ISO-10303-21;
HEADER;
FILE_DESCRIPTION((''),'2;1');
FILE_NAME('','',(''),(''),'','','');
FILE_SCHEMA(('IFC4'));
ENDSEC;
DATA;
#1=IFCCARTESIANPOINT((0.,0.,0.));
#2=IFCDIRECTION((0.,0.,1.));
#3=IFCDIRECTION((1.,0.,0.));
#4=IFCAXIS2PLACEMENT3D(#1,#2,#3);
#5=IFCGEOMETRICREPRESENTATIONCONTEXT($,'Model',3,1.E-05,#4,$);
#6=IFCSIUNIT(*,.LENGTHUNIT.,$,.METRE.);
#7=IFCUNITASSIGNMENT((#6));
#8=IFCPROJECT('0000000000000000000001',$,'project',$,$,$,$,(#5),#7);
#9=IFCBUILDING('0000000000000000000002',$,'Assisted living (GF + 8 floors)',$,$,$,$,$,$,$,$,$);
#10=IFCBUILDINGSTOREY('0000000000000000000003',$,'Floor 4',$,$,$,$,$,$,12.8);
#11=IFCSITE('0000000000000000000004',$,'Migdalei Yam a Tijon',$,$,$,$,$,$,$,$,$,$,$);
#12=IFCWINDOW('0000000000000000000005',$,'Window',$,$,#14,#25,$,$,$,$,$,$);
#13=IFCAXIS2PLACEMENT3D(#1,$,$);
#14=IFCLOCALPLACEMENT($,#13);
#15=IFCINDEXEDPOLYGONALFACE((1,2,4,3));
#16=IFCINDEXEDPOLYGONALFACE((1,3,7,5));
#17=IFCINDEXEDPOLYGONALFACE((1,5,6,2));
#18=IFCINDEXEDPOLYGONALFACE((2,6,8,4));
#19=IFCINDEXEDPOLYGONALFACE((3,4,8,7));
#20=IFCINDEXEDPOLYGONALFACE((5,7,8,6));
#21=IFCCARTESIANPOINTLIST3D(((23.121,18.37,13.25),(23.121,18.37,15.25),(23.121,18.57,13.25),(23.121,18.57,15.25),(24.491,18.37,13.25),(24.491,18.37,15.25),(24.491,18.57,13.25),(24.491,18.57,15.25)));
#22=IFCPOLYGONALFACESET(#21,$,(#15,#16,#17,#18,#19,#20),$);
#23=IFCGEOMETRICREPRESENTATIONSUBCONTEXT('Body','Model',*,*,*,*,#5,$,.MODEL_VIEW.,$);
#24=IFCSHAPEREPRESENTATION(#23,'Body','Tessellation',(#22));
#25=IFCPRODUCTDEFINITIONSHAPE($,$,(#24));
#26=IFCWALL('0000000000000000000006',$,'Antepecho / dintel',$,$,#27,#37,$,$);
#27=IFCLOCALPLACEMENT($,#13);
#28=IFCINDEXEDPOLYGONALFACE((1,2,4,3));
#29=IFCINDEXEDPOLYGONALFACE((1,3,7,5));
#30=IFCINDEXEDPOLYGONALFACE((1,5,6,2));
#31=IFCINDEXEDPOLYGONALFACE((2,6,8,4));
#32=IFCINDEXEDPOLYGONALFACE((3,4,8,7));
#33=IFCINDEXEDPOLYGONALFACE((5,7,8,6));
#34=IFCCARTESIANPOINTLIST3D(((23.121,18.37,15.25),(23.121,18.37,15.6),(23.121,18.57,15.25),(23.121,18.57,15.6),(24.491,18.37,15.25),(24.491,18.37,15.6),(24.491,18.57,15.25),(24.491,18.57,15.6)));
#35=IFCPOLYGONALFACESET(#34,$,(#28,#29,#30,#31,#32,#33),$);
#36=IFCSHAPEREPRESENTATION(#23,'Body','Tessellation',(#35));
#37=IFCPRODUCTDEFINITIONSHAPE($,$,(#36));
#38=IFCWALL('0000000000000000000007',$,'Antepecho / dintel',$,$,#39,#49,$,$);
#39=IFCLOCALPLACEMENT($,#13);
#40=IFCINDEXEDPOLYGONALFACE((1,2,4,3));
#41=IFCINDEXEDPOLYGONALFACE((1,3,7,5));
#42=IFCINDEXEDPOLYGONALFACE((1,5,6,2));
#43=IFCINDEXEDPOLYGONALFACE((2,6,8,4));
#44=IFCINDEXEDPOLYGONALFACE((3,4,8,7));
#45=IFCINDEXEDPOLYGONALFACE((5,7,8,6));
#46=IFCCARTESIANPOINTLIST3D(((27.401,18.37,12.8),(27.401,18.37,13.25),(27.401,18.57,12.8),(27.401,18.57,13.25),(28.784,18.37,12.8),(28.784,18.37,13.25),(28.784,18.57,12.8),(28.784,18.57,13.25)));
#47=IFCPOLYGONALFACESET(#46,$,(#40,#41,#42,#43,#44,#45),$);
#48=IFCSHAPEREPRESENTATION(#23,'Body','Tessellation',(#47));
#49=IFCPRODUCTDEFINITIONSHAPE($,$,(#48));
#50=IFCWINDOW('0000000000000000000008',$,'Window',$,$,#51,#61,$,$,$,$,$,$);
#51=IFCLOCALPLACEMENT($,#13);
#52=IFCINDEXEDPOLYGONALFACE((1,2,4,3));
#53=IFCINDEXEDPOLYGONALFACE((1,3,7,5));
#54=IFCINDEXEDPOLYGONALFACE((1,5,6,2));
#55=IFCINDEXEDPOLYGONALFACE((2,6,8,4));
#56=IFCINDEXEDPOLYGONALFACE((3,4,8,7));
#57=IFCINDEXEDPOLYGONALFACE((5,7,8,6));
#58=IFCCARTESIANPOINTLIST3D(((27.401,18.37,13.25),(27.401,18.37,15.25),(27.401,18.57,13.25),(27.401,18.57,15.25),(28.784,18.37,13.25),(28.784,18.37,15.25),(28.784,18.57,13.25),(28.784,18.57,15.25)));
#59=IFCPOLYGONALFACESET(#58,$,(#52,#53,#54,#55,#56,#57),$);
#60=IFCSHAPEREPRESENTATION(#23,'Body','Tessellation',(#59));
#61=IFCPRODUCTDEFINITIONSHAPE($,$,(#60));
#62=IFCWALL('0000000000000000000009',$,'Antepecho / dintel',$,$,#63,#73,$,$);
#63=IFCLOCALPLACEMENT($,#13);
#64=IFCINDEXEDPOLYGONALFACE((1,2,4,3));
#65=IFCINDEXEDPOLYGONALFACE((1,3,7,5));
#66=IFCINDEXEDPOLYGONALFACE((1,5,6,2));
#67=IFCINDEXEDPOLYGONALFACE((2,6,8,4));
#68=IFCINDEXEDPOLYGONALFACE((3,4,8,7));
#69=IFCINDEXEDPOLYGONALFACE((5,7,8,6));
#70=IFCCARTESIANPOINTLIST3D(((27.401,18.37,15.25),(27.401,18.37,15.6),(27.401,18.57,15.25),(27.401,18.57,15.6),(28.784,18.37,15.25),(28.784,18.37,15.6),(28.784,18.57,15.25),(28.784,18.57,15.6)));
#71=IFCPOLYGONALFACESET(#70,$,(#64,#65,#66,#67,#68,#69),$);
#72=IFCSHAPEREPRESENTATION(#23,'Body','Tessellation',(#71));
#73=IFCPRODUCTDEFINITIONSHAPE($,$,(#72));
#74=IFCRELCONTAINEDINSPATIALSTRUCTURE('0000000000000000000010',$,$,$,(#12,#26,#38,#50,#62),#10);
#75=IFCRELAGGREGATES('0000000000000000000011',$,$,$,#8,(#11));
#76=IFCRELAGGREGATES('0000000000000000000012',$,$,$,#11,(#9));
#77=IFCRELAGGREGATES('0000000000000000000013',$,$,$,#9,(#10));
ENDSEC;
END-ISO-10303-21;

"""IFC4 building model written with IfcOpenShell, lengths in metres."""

from ifc_helpers import new_model, si_unit, frame, origin_with_axes, context, subcontext, project, spatial, line, indexed_curve, outline, extrude, element, save


model = new_model("IFC4")

# Units and contexts
model_context = context("Model", 3, precision=1e-05, world=origin_with_axes())
body_context = subcontext(model_context, "Body", "Model", "MODEL_VIEW")
ifc_project = project(units=[si_unit("LENGTHUNIT", "METRE")], contexts=[model_context])

# Site, building, storey
site = spatial("IfcSite", under=ifc_project, Name="Migdalei Yam a Tijon")
building = spatial("IfcBuilding", under=site, Name="Assisted living (GF + 8 floors)")
storey = spatial("IfcBuildingStorey", under=building, Name="Floor 4", Elevation=12.8)

# Window
element("IfcWindow", 1, inside=storey, Name="Window", context=body_context, shape_type="SweptSolid", body=[
    extrude(outline(indexed_curve([(0.0, 0.0), (1.37, 0.0), (1.37, 0.2), (0.0, 0.2)], segments=[line(1, 2, 3, 4, 1)])), frame((23.121, 18.37, 13.25), z_axis=(0.0, 0.0, 1.0), x_axis=(1.0, 0.0, 0.0)), (0.0, 0.0, 1.0), 2.0),
])

# Walls
element("IfcWall", 2, inside=storey, Name="Antepecho / dintel", context=body_context, shape_type="SweptSolid", body=[
    extrude(outline(indexed_curve([(0.0, 0.0), (1.37, 0.0), (1.37, 0.2), (0.0, 0.2)], segments=[line(1, 2, 3, 4, 1)])), frame((23.121, 18.37, 15.25), z_axis=(0.0, 0.0, 1.0), x_axis=(1.0, 0.0, 0.0)), (0.0, 0.0, 1.0), 0.35),
])
element("IfcWall", 3, inside=storey, Name="Antepecho / dintel", context=body_context, shape_type="SweptSolid", body=[
    extrude(outline(indexed_curve([(0.0, 0.0), (1.383, 0.0), (1.383, 0.2), (0.0, 0.2)], segments=[line(1, 2, 3, 4, 1)])), frame((27.401, 18.37, 12.8), z_axis=(0.0, 0.0, 1.0), x_axis=(1.0, 0.0, 0.0)), (0.0, 0.0, 1.0), 0.45),
])

# Window
element("IfcWindow", 4, inside=storey, Name="Window", context=body_context, shape_type="SweptSolid", body=[
    extrude(outline(indexed_curve([(0.0, 0.0), (1.383, 0.0), (1.383, 0.2), (0.0, 0.2)], segments=[line(1, 2, 3, 4, 1)])), frame((27.401, 18.37, 13.25), z_axis=(0.0, 0.0, 1.0), x_axis=(1.0, 0.0, 0.0)), (0.0, 0.0, 1.0), 2.0),
])

# Wall
element("IfcWall", 5, inside=storey, Name="Antepecho / dintel", context=body_context, shape_type="SweptSolid", body=[
    extrude(outline(indexed_curve([(0.0, 0.0), (1.383, 0.0), (1.383, 0.2), (0.0, 0.2)], segments=[line(1, 2, 3, 4, 1)])), frame((27.401, 18.37, 15.25), z_axis=(0.0, 0.0, 1.0), x_axis=(1.0, 0.0, 0.0)), (0.0, 0.0, 1.0), 0.35),
])

save(model, "model.ifc")
